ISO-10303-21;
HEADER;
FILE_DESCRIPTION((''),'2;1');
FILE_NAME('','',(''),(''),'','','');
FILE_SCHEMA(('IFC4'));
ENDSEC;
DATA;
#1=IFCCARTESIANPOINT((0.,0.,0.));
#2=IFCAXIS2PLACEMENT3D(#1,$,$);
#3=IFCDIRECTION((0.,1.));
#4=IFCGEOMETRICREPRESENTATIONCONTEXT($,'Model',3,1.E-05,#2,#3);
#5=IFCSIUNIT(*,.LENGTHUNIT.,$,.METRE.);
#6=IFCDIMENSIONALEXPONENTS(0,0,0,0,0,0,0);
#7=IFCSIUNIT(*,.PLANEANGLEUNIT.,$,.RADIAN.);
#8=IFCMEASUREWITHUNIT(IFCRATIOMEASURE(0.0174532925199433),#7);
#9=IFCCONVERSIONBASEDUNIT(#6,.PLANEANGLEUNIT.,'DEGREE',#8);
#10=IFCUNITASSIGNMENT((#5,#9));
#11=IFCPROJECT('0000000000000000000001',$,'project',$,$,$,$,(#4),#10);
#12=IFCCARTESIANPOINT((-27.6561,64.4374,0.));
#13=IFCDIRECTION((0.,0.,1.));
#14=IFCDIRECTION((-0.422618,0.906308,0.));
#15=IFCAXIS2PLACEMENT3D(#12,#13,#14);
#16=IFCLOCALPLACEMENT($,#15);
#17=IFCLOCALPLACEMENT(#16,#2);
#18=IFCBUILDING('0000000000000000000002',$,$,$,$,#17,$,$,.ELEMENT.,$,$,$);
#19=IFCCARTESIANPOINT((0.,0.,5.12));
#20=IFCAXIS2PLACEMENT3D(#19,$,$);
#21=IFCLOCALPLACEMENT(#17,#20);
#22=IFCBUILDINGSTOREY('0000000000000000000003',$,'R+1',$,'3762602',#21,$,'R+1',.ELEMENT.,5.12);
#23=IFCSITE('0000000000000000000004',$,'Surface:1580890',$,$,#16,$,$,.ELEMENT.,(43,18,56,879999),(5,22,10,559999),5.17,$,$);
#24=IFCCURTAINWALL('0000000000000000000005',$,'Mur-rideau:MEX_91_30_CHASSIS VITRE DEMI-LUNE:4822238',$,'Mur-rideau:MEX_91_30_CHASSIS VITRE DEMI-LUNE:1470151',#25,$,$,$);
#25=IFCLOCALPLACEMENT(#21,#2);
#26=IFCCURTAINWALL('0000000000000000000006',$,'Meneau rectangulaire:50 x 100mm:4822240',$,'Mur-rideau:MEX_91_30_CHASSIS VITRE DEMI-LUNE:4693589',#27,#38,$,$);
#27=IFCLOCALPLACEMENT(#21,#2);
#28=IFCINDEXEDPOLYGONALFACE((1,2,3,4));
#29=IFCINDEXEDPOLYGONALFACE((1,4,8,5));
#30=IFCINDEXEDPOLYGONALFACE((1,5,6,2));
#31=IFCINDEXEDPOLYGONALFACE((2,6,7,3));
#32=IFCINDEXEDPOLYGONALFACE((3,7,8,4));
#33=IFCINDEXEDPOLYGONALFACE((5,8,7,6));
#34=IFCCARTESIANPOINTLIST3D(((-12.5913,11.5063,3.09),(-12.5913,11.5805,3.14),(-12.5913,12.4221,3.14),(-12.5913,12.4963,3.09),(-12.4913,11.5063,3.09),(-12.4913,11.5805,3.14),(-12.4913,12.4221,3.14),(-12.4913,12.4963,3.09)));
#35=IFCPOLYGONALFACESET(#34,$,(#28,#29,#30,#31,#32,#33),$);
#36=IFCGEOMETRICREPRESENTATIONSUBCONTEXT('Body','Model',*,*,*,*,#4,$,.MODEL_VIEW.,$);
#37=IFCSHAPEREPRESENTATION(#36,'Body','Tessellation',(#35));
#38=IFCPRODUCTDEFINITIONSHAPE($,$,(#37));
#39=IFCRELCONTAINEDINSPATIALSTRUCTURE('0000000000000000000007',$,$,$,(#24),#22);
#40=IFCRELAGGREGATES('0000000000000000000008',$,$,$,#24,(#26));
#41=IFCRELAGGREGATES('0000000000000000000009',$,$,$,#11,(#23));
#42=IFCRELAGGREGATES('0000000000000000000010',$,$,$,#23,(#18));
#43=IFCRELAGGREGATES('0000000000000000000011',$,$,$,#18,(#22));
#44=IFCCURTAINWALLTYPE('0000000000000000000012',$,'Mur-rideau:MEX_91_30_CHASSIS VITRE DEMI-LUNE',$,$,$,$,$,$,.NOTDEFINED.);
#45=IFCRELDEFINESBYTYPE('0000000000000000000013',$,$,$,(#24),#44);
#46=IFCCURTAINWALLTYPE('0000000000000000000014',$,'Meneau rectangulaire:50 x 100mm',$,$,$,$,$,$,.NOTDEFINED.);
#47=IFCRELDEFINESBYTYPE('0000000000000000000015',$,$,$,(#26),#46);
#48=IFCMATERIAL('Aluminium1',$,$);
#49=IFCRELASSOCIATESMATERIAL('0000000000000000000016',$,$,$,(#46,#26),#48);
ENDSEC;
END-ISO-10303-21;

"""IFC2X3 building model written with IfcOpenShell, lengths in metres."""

from ifc_helpers import new_model, entity, si_unit, converted_unit, direction, frame, origin, place, context, subcontext, project, spatial, polyline, outline, extrude, source, transform, mapped, material, type_object, type_shapes, element, aggregate, save


model = new_model("IFC2X3")

# Units and contexts
model_context = context("Model", 3, precision=1e-05, world=origin(), true_north=direction((0.0, 1.0)))
body_context = subcontext(model_context, "Body", "Model", "MODEL_VIEW")
ifc_project = project(units=[si_unit("LENGTHUNIT", "METRE"), converted_unit("PLANEANGLEUNIT", "DEGREE", entity("IfcRatioMeasure", 0.0174532925199433), si_unit("PLANEANGLEUNIT", "RADIAN"), dimensions=[0, 0, 0, 0, 0, 0, 0])], contexts=[model_context])

# Site, building, storey
site_placement = place(None, frame((-27.6561, 64.4374, 0.0), z_axis=(0.0, 0.0, 1.0), x_axis=(-0.422618, 0.906308, 0.0)))
site = spatial("IfcSite", under=ifc_project, at=site_placement, Name="Surface:1580890", CompositionType="ELEMENT", RefLatitude=(43, 18, 56, 879999), RefLongitude=(5, 22, 10, 559999), RefElevation=5.17)
building_placement = place(site_placement, origin())
building = spatial("IfcBuilding", under=site, at=building_placement, CompositionType="ELEMENT")
storey_placement = place(building_placement, frame((0.0, 0.0, 5.12)))
storey = spatial("IfcBuildingStorey", under=building, at=storey_placement, Name="R+1", ObjectType="3762602", LongName="R+1", CompositionType="ELEMENT", Elevation=5.12)

# Curtain walls
curtain_wall_type_1 = type_object("IfcCurtainWallType", Name="Mur-rideau:MEX_91_30_CHASSIS VITRE DEMI-LUNE", PredefinedType="NOTDEFINED")
ifc_material_1 = material(Name="Aluminium1")
curtain_wall_type_2 = type_object("IfcCurtainWallType", Name="Meneau rectangulaire:50 x 100mm", PredefinedType="NOTDEFINED", material=ifc_material_1)
shared_shape_1 = source(origin(), body_context, "Body", "SweptSolid", [
    extrude(outline(polyline([(-0.495, -0.025), (0.495, -0.025), (0.4208, 0.025), (-0.4208, 0.025), (-0.495, -0.025)])), frame((-0.025, -0.05, -0.495), z_axis=(0.0, 1.0, 0.0), x_axis=(0.0, 0.0, -1.0)), (0.0, 0.0, 1.0), 0.1),
])
type_shapes(curtain_wall_type_2, [shared_shape_1])
placement = place(building_placement, frame((0.0, 0.0, 2.56)))
curtain_wall_1_placement = place(storey_placement, frame((0.0, 0.0, -5.12)))
curtain_wall_1 = element("IfcCurtainWall", 1, at=curtain_wall_1_placement, inside=storey, type_object=curtain_wall_type_1, Name="Mur-rideau:MEX_91_30_CHASSIS VITRE DEMI-LUNE:4822238", ObjectType="Mur-rideau:MEX_91_30_CHASSIS VITRE DEMI-LUNE:1470151")
curtain_wall_2_placement = place(placement, frame((-12.5413, 12.4963, 5.65), z_axis=(0.0, 1.0, 0.0), x_axis=(0.0, 0.0, -1.0)))
curtain_wall_2 = element("IfcCurtainWall", 2, at=curtain_wall_2_placement, type_object=curtain_wall_type_2, material=ifc_material_1, Name="Meneau rectangulaire:50 x 100mm:4822240", ObjectType="Mur-rideau:MEX_91_30_CHASSIS VITRE DEMI-LUNE:4693589", context=body_context, shape_type="MappedRepresentation", body=[
    mapped(shared_shape_1, transform((0.0, 0.0, 0.0), scale=1.0)),
])
aggregate(curtain_wall_1, [curtain_wall_2])

save(model, "model.ifc")
